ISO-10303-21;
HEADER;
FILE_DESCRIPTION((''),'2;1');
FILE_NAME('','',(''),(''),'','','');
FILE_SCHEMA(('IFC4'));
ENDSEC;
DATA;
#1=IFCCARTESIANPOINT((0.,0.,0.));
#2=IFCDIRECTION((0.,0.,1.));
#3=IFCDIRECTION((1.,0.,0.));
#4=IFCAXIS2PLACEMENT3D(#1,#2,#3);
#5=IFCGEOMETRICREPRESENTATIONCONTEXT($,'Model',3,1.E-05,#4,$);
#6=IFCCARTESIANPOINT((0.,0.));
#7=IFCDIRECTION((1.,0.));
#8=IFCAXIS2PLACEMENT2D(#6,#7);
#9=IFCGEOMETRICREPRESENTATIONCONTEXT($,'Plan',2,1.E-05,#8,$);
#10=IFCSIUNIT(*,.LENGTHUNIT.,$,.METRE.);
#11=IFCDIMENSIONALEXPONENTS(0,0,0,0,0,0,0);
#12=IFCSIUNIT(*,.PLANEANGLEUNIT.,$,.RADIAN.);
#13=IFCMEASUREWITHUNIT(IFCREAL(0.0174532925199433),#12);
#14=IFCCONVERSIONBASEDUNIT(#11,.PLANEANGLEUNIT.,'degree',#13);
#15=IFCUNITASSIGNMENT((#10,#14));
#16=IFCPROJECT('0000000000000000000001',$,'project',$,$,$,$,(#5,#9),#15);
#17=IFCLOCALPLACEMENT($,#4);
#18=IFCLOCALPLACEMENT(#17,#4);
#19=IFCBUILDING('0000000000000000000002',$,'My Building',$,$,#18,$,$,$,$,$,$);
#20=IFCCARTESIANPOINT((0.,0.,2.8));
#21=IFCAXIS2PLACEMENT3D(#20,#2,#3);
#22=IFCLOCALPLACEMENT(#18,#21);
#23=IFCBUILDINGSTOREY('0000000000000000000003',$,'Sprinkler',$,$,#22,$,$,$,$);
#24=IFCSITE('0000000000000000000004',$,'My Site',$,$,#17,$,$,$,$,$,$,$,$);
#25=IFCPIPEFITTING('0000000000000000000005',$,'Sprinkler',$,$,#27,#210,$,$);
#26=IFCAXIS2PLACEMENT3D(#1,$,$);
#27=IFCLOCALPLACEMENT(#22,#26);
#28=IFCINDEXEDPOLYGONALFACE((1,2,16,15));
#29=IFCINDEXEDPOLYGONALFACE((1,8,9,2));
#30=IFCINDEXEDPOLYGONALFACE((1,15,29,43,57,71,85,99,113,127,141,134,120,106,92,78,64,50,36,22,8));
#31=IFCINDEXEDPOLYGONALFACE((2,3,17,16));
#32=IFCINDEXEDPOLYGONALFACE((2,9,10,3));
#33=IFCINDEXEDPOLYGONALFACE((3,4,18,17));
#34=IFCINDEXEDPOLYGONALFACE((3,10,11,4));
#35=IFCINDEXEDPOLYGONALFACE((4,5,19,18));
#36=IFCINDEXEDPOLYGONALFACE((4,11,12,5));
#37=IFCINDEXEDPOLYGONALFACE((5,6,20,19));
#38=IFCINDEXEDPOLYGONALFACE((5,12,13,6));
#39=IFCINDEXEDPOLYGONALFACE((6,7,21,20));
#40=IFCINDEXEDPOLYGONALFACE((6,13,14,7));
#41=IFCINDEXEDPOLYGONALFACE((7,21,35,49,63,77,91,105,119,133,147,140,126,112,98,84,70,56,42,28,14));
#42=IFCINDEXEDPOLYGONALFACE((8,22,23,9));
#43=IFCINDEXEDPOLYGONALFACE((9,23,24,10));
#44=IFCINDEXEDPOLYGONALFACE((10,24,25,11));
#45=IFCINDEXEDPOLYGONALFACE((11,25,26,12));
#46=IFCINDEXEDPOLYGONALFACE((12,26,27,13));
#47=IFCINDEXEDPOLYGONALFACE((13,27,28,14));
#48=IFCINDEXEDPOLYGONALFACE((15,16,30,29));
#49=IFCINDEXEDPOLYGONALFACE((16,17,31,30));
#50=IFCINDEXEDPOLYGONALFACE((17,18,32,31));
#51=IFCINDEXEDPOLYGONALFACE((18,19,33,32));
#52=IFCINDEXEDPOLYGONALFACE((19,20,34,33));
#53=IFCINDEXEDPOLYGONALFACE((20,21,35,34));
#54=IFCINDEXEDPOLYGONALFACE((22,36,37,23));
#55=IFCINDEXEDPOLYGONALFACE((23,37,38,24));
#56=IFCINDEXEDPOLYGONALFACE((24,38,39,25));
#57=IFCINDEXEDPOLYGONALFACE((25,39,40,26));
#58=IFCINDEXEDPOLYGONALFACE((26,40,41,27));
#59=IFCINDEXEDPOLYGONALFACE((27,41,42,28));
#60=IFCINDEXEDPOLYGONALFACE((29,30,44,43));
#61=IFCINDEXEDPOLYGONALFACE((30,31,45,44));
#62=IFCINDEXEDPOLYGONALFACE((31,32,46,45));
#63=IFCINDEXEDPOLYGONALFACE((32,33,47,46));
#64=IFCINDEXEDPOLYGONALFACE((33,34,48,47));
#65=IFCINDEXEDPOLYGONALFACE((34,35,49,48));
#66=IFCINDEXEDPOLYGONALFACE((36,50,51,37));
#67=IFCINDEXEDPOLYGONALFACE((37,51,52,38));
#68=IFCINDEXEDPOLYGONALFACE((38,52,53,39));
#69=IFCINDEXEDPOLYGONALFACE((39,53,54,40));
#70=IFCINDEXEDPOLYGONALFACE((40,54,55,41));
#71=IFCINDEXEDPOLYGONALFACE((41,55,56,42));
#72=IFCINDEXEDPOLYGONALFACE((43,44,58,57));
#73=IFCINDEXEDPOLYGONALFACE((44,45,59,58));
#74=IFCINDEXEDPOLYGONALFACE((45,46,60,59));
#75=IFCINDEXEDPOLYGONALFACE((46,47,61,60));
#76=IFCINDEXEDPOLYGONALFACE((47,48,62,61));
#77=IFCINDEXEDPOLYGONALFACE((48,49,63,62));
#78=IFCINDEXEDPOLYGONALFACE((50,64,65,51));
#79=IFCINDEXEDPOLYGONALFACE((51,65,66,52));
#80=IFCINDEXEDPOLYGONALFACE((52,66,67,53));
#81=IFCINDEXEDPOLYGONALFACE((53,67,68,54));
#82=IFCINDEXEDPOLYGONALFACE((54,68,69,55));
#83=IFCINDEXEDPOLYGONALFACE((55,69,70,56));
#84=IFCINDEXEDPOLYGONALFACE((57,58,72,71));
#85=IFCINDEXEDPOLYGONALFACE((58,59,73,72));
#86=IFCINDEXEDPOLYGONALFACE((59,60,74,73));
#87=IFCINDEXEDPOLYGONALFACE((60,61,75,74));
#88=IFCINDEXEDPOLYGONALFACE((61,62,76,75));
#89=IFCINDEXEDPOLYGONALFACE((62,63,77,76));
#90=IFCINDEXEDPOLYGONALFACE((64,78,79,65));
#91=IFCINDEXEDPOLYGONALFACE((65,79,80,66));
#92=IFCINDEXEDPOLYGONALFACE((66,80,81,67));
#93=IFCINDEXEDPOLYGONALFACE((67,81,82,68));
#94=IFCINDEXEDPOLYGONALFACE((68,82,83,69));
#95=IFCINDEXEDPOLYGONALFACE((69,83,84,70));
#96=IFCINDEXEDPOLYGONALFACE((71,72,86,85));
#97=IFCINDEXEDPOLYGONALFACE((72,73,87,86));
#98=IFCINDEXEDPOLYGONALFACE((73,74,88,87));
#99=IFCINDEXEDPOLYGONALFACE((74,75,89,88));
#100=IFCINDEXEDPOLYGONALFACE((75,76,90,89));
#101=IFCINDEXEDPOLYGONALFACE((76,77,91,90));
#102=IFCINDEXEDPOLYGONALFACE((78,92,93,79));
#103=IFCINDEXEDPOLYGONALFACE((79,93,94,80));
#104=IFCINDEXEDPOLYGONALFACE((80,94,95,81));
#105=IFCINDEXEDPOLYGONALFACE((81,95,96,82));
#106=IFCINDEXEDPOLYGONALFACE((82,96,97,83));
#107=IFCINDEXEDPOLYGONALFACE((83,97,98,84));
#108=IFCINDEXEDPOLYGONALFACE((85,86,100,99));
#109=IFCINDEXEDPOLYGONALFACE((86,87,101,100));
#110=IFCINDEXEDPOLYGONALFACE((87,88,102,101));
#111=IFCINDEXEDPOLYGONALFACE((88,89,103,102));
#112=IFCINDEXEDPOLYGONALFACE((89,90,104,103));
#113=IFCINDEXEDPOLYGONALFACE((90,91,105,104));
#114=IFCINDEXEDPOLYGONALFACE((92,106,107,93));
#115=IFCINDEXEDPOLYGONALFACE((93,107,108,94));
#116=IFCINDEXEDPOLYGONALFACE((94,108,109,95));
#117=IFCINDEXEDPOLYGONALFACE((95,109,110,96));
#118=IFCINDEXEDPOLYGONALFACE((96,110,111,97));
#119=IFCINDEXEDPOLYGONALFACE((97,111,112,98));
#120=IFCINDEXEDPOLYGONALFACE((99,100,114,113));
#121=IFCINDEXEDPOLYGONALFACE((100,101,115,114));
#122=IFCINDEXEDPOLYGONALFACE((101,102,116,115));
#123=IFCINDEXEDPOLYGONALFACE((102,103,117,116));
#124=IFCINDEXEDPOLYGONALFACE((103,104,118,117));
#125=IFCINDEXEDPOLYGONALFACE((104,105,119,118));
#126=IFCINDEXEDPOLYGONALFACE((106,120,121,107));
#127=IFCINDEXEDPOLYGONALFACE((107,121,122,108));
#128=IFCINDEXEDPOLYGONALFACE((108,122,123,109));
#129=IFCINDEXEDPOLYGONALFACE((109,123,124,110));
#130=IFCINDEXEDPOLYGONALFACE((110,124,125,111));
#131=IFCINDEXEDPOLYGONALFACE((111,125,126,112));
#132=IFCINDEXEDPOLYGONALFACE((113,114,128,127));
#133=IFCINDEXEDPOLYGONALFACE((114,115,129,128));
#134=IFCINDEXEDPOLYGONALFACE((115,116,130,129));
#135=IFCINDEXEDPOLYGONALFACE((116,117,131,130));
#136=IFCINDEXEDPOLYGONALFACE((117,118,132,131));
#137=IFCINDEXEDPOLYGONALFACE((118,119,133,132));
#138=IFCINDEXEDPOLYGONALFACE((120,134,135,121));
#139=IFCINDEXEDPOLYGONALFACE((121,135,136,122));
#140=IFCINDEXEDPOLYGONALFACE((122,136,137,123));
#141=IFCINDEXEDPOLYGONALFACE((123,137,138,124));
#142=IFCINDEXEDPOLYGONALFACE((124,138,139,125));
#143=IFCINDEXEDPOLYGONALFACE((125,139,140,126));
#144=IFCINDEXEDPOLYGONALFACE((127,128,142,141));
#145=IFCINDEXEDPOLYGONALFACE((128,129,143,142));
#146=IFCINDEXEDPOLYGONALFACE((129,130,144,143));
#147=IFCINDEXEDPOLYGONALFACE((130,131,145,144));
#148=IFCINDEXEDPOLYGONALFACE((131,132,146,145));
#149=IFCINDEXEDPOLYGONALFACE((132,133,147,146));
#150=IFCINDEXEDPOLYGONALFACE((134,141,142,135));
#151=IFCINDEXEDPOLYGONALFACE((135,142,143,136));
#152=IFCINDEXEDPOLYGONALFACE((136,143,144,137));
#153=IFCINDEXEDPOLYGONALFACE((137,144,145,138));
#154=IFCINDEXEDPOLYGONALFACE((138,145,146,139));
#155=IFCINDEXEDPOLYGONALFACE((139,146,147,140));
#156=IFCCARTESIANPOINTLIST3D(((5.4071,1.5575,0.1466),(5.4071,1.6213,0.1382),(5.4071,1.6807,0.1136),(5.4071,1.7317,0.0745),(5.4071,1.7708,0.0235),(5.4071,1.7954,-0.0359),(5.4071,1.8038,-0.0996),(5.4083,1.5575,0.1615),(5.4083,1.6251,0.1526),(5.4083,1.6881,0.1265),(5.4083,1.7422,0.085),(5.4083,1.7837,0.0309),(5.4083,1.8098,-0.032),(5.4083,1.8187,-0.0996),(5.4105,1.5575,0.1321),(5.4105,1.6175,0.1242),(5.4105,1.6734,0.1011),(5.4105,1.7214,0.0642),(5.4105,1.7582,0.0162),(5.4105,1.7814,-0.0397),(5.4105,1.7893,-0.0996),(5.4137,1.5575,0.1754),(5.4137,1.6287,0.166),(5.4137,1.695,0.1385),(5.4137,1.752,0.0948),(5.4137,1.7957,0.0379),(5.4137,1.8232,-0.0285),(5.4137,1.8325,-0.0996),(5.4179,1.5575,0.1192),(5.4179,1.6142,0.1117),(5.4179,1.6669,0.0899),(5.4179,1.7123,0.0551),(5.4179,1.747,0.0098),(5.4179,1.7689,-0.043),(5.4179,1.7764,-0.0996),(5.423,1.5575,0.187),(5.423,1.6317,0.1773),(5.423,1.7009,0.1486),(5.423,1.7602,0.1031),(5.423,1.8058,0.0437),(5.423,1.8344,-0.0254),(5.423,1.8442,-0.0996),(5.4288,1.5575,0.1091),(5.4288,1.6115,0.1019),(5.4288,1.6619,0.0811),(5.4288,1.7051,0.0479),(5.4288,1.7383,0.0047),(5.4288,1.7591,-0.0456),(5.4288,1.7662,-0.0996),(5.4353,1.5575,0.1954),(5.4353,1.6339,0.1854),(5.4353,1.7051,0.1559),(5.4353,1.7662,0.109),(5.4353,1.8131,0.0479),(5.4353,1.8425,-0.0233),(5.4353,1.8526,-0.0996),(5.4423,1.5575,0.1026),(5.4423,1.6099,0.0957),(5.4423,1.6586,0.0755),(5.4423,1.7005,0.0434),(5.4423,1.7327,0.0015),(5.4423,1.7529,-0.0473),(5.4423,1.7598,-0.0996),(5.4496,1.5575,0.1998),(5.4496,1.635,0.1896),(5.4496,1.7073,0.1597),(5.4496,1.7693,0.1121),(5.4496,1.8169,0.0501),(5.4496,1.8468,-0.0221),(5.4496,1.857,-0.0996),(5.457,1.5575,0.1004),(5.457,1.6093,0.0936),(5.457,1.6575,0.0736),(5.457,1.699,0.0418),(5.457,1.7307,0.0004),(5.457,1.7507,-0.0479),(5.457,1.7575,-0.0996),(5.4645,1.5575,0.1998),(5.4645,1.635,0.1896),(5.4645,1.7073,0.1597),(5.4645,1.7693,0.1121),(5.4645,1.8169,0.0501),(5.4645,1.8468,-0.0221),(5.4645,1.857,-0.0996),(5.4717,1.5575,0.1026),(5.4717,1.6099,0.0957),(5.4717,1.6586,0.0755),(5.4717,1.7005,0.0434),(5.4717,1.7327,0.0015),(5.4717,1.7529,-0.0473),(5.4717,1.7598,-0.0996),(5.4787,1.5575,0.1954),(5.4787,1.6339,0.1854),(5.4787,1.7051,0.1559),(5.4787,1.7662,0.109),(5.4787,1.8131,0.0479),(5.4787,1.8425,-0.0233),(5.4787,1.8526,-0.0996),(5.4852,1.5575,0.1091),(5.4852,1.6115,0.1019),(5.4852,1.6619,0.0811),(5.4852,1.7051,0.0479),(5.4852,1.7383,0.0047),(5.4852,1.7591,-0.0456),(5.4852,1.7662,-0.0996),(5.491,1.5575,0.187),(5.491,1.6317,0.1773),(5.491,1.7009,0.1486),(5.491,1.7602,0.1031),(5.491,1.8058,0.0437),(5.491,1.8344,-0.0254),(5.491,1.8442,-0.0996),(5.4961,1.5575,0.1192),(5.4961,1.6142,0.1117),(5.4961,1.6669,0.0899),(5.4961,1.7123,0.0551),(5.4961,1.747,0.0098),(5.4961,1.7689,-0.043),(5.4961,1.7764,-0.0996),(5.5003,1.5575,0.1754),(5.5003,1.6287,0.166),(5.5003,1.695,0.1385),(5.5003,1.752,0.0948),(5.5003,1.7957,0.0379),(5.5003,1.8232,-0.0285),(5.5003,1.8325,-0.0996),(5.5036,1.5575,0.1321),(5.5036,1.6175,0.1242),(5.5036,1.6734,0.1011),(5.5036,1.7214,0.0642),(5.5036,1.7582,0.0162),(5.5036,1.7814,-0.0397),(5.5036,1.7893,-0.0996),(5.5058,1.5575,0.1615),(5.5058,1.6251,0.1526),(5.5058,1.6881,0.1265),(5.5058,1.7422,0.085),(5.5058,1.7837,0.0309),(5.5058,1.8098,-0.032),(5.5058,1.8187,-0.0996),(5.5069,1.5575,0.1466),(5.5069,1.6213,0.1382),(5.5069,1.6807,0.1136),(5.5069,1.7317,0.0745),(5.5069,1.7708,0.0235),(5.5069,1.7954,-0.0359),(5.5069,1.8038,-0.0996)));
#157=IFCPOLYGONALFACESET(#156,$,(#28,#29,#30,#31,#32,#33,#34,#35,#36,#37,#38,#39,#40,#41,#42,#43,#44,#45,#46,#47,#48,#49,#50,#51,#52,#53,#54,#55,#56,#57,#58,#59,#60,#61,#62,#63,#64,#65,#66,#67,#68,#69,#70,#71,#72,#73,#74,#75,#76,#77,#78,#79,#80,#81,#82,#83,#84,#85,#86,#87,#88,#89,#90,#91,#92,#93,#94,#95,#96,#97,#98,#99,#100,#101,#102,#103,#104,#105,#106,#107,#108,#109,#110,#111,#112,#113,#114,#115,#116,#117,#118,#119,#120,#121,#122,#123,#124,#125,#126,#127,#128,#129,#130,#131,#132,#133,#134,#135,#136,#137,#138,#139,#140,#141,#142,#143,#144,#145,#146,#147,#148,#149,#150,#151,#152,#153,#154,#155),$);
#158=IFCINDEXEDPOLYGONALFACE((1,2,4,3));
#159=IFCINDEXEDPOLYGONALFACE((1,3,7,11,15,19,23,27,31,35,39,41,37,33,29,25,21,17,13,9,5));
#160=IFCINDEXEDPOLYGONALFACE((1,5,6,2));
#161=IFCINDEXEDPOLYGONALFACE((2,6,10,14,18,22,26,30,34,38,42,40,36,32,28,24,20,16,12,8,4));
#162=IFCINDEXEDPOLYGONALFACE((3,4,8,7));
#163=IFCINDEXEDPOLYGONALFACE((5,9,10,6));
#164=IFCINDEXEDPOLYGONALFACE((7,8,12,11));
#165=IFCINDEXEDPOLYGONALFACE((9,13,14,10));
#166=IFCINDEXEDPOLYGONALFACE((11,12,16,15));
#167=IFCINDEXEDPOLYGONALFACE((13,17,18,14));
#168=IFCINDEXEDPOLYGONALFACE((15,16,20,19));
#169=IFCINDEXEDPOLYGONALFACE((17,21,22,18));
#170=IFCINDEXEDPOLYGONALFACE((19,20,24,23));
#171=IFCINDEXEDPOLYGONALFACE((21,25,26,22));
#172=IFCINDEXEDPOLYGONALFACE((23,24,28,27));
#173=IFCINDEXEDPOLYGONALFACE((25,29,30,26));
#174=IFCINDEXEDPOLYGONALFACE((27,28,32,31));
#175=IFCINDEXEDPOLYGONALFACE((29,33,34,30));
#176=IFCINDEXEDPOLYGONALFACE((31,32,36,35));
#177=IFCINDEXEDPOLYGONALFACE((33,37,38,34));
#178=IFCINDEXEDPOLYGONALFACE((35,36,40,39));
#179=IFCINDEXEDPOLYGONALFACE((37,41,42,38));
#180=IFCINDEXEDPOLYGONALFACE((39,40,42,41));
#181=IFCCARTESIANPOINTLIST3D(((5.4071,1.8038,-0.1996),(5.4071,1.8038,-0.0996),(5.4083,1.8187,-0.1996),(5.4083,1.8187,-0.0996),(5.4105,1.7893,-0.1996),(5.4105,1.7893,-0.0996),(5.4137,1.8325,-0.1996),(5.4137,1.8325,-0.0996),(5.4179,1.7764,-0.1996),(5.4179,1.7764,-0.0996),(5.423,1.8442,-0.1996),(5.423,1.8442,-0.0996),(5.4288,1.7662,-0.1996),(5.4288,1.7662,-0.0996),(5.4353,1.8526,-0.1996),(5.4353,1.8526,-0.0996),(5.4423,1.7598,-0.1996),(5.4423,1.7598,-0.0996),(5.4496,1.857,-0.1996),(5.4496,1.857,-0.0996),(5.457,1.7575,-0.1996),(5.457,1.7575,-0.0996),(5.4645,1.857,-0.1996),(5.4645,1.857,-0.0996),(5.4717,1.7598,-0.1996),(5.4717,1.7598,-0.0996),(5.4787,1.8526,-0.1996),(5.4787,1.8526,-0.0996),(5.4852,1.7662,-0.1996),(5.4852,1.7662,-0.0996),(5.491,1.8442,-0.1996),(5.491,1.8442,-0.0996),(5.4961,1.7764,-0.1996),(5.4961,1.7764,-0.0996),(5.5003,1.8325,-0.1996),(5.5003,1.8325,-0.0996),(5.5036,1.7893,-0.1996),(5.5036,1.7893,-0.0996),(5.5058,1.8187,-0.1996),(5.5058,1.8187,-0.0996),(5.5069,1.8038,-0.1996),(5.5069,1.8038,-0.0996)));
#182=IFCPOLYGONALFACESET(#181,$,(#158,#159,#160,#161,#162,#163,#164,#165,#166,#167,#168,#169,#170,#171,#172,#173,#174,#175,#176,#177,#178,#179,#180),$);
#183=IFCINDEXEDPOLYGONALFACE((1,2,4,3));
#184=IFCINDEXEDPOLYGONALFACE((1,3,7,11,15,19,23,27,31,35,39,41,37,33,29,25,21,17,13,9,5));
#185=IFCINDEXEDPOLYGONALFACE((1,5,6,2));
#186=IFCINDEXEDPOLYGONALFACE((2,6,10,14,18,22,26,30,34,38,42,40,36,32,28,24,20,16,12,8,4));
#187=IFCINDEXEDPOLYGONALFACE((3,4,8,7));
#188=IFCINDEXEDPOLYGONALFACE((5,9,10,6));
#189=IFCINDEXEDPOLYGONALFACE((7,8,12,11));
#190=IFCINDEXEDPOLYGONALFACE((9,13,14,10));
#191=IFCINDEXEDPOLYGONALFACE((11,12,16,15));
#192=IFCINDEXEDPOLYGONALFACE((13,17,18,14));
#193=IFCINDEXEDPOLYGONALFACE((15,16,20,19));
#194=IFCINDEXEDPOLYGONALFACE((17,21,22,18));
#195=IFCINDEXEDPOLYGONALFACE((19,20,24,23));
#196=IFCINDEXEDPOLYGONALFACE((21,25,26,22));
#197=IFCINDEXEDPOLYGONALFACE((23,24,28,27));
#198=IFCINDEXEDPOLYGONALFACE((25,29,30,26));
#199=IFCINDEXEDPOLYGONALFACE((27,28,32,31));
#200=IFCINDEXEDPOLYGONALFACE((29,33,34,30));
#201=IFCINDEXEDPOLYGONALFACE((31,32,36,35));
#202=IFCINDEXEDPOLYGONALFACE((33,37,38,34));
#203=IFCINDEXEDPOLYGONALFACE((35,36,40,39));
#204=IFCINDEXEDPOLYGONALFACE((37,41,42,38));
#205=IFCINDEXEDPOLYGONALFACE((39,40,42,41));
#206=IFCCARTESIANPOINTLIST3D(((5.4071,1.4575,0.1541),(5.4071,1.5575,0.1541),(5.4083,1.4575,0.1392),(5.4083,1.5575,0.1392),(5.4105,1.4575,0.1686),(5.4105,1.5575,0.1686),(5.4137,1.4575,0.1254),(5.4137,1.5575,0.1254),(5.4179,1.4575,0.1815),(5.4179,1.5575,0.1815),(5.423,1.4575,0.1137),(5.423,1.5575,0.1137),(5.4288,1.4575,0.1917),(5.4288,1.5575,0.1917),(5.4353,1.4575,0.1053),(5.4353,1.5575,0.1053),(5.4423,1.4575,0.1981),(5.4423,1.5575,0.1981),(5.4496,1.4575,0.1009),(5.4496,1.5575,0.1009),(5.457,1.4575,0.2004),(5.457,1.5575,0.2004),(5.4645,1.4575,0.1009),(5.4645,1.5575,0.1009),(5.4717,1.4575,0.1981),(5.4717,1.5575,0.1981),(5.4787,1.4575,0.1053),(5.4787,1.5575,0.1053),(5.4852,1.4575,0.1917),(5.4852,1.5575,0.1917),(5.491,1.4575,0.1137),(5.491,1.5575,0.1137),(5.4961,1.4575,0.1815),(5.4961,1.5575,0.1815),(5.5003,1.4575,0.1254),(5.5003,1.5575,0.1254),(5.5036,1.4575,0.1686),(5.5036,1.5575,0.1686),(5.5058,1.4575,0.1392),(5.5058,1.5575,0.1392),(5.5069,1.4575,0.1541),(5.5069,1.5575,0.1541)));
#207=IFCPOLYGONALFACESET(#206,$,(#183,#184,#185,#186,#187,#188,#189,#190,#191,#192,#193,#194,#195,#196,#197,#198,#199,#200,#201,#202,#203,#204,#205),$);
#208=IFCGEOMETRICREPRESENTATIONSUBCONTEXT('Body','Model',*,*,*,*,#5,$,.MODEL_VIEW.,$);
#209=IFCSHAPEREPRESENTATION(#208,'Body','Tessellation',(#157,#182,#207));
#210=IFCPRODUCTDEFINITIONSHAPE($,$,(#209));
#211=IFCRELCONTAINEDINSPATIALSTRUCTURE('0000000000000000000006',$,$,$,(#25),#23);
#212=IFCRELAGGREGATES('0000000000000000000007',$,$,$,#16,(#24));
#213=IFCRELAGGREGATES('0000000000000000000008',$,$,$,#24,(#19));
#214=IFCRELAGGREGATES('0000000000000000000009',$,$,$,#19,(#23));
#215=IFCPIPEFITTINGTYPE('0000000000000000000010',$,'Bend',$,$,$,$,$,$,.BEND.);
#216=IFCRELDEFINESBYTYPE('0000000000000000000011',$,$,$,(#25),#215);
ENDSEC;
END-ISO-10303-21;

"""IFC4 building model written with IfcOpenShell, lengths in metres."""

from ifc_helpers import new_model, entity, si_unit, converted_unit, frame, origin_with_axes, origin_2d_with_axis, place, context, subcontext, project, spatial, circle, extrude, source, transform, mapped, type_object, type_shapes, element, save


model = new_model("IFC4")

# Units and contexts
model_context = context("Model", 3, precision=1e-05, world=origin_with_axes())
plan_context = context("Plan", 2, precision=1e-05, world=origin_2d_with_axis())
body_context = subcontext(model_context, "Body", "Model", "MODEL_VIEW")
ifc_project = project(units=[si_unit("LENGTHUNIT", "METRE"), converted_unit("PLANEANGLEUNIT", "degree", entity("IfcReal", 0.0174532925199433), si_unit("PLANEANGLEUNIT", "RADIAN"), dimensions=[0, 0, 0, 0, 0, 0, 0])], contexts=[model_context, plan_context])

# Site, building, storey
site_placement = place(None, origin_with_axes())
site = spatial("IfcSite", under=ifc_project, at=site_placement, Name="My Site")
building_placement = place(site_placement, origin_with_axes())
building = spatial("IfcBuilding", under=site, at=building_placement, Name="My Building")
storey_placement = place(building_placement, frame((0.0, 0.0, 2.8), z_axis=(0.0, 0.0, 1.0), x_axis=(1.0, 0.0, 0.0)))
storey = spatial("IfcBuildingStorey", under=building, at=storey_placement, Name="Sprinkler")

# Pipe fitting
pipe_fitting_type_1 = type_object("IfcPipeFittingType", Name="Bend", PredefinedType="BEND")
shared_shape = source(origin_with_axes(), body_context, "Body", "SolidModel", [
    entity("IfcSweptDiskSolid", entity("IfcIndexedPolyCurve", entity("IfcCartesianPointList3D", [[0.0, 0.0, 0.1], [0.0732, 0.0, 0.2768], [0.25, 0.0, 0.35]]), [entity("IfcArcIndex", [1, 2, 3])]), 0.05),
    extrude(circle(Radius=0.05), origin_with_axes(), (0.0, 0.0, 1.0), 0.1),
    extrude(circle(Radius=0.05), frame((0.25, 0.0, 0.35), z_axis=(1.0, 0.0, 0.000001), x_axis=(-0.000001, 0.0, 1.0)), (0.0, 0.0, 1.0), 0.1),
])
type_shapes(pipe_fitting_type_1, [shared_shape])
for number, where, z_axis, x_axis, name in (
    (1, (5.457, 1.8075, -0.1996), (0.0, -0.000008, 1.0), (0.0, -1.0, -0.000008), "Sprinkler"),
):
    element("IfcPipeFitting", number, at=place(storey_placement, frame(where, z_axis=z_axis, x_axis=x_axis)), inside=storey, type_object=pipe_fitting_type_1, Name=name, context=body_context, shape_type="MappedRepresentation", body=[
        mapped(shared_shape, transform((0.0, 0.0, 0.0), x_axis=(1.0, 0.0, 0.0), y_axis=(0.0, 1.0, 0.0), z_axis=(0.0, 0.0, 1.0), scale=1.0)),
    ])

save(model, "model.ifc")
